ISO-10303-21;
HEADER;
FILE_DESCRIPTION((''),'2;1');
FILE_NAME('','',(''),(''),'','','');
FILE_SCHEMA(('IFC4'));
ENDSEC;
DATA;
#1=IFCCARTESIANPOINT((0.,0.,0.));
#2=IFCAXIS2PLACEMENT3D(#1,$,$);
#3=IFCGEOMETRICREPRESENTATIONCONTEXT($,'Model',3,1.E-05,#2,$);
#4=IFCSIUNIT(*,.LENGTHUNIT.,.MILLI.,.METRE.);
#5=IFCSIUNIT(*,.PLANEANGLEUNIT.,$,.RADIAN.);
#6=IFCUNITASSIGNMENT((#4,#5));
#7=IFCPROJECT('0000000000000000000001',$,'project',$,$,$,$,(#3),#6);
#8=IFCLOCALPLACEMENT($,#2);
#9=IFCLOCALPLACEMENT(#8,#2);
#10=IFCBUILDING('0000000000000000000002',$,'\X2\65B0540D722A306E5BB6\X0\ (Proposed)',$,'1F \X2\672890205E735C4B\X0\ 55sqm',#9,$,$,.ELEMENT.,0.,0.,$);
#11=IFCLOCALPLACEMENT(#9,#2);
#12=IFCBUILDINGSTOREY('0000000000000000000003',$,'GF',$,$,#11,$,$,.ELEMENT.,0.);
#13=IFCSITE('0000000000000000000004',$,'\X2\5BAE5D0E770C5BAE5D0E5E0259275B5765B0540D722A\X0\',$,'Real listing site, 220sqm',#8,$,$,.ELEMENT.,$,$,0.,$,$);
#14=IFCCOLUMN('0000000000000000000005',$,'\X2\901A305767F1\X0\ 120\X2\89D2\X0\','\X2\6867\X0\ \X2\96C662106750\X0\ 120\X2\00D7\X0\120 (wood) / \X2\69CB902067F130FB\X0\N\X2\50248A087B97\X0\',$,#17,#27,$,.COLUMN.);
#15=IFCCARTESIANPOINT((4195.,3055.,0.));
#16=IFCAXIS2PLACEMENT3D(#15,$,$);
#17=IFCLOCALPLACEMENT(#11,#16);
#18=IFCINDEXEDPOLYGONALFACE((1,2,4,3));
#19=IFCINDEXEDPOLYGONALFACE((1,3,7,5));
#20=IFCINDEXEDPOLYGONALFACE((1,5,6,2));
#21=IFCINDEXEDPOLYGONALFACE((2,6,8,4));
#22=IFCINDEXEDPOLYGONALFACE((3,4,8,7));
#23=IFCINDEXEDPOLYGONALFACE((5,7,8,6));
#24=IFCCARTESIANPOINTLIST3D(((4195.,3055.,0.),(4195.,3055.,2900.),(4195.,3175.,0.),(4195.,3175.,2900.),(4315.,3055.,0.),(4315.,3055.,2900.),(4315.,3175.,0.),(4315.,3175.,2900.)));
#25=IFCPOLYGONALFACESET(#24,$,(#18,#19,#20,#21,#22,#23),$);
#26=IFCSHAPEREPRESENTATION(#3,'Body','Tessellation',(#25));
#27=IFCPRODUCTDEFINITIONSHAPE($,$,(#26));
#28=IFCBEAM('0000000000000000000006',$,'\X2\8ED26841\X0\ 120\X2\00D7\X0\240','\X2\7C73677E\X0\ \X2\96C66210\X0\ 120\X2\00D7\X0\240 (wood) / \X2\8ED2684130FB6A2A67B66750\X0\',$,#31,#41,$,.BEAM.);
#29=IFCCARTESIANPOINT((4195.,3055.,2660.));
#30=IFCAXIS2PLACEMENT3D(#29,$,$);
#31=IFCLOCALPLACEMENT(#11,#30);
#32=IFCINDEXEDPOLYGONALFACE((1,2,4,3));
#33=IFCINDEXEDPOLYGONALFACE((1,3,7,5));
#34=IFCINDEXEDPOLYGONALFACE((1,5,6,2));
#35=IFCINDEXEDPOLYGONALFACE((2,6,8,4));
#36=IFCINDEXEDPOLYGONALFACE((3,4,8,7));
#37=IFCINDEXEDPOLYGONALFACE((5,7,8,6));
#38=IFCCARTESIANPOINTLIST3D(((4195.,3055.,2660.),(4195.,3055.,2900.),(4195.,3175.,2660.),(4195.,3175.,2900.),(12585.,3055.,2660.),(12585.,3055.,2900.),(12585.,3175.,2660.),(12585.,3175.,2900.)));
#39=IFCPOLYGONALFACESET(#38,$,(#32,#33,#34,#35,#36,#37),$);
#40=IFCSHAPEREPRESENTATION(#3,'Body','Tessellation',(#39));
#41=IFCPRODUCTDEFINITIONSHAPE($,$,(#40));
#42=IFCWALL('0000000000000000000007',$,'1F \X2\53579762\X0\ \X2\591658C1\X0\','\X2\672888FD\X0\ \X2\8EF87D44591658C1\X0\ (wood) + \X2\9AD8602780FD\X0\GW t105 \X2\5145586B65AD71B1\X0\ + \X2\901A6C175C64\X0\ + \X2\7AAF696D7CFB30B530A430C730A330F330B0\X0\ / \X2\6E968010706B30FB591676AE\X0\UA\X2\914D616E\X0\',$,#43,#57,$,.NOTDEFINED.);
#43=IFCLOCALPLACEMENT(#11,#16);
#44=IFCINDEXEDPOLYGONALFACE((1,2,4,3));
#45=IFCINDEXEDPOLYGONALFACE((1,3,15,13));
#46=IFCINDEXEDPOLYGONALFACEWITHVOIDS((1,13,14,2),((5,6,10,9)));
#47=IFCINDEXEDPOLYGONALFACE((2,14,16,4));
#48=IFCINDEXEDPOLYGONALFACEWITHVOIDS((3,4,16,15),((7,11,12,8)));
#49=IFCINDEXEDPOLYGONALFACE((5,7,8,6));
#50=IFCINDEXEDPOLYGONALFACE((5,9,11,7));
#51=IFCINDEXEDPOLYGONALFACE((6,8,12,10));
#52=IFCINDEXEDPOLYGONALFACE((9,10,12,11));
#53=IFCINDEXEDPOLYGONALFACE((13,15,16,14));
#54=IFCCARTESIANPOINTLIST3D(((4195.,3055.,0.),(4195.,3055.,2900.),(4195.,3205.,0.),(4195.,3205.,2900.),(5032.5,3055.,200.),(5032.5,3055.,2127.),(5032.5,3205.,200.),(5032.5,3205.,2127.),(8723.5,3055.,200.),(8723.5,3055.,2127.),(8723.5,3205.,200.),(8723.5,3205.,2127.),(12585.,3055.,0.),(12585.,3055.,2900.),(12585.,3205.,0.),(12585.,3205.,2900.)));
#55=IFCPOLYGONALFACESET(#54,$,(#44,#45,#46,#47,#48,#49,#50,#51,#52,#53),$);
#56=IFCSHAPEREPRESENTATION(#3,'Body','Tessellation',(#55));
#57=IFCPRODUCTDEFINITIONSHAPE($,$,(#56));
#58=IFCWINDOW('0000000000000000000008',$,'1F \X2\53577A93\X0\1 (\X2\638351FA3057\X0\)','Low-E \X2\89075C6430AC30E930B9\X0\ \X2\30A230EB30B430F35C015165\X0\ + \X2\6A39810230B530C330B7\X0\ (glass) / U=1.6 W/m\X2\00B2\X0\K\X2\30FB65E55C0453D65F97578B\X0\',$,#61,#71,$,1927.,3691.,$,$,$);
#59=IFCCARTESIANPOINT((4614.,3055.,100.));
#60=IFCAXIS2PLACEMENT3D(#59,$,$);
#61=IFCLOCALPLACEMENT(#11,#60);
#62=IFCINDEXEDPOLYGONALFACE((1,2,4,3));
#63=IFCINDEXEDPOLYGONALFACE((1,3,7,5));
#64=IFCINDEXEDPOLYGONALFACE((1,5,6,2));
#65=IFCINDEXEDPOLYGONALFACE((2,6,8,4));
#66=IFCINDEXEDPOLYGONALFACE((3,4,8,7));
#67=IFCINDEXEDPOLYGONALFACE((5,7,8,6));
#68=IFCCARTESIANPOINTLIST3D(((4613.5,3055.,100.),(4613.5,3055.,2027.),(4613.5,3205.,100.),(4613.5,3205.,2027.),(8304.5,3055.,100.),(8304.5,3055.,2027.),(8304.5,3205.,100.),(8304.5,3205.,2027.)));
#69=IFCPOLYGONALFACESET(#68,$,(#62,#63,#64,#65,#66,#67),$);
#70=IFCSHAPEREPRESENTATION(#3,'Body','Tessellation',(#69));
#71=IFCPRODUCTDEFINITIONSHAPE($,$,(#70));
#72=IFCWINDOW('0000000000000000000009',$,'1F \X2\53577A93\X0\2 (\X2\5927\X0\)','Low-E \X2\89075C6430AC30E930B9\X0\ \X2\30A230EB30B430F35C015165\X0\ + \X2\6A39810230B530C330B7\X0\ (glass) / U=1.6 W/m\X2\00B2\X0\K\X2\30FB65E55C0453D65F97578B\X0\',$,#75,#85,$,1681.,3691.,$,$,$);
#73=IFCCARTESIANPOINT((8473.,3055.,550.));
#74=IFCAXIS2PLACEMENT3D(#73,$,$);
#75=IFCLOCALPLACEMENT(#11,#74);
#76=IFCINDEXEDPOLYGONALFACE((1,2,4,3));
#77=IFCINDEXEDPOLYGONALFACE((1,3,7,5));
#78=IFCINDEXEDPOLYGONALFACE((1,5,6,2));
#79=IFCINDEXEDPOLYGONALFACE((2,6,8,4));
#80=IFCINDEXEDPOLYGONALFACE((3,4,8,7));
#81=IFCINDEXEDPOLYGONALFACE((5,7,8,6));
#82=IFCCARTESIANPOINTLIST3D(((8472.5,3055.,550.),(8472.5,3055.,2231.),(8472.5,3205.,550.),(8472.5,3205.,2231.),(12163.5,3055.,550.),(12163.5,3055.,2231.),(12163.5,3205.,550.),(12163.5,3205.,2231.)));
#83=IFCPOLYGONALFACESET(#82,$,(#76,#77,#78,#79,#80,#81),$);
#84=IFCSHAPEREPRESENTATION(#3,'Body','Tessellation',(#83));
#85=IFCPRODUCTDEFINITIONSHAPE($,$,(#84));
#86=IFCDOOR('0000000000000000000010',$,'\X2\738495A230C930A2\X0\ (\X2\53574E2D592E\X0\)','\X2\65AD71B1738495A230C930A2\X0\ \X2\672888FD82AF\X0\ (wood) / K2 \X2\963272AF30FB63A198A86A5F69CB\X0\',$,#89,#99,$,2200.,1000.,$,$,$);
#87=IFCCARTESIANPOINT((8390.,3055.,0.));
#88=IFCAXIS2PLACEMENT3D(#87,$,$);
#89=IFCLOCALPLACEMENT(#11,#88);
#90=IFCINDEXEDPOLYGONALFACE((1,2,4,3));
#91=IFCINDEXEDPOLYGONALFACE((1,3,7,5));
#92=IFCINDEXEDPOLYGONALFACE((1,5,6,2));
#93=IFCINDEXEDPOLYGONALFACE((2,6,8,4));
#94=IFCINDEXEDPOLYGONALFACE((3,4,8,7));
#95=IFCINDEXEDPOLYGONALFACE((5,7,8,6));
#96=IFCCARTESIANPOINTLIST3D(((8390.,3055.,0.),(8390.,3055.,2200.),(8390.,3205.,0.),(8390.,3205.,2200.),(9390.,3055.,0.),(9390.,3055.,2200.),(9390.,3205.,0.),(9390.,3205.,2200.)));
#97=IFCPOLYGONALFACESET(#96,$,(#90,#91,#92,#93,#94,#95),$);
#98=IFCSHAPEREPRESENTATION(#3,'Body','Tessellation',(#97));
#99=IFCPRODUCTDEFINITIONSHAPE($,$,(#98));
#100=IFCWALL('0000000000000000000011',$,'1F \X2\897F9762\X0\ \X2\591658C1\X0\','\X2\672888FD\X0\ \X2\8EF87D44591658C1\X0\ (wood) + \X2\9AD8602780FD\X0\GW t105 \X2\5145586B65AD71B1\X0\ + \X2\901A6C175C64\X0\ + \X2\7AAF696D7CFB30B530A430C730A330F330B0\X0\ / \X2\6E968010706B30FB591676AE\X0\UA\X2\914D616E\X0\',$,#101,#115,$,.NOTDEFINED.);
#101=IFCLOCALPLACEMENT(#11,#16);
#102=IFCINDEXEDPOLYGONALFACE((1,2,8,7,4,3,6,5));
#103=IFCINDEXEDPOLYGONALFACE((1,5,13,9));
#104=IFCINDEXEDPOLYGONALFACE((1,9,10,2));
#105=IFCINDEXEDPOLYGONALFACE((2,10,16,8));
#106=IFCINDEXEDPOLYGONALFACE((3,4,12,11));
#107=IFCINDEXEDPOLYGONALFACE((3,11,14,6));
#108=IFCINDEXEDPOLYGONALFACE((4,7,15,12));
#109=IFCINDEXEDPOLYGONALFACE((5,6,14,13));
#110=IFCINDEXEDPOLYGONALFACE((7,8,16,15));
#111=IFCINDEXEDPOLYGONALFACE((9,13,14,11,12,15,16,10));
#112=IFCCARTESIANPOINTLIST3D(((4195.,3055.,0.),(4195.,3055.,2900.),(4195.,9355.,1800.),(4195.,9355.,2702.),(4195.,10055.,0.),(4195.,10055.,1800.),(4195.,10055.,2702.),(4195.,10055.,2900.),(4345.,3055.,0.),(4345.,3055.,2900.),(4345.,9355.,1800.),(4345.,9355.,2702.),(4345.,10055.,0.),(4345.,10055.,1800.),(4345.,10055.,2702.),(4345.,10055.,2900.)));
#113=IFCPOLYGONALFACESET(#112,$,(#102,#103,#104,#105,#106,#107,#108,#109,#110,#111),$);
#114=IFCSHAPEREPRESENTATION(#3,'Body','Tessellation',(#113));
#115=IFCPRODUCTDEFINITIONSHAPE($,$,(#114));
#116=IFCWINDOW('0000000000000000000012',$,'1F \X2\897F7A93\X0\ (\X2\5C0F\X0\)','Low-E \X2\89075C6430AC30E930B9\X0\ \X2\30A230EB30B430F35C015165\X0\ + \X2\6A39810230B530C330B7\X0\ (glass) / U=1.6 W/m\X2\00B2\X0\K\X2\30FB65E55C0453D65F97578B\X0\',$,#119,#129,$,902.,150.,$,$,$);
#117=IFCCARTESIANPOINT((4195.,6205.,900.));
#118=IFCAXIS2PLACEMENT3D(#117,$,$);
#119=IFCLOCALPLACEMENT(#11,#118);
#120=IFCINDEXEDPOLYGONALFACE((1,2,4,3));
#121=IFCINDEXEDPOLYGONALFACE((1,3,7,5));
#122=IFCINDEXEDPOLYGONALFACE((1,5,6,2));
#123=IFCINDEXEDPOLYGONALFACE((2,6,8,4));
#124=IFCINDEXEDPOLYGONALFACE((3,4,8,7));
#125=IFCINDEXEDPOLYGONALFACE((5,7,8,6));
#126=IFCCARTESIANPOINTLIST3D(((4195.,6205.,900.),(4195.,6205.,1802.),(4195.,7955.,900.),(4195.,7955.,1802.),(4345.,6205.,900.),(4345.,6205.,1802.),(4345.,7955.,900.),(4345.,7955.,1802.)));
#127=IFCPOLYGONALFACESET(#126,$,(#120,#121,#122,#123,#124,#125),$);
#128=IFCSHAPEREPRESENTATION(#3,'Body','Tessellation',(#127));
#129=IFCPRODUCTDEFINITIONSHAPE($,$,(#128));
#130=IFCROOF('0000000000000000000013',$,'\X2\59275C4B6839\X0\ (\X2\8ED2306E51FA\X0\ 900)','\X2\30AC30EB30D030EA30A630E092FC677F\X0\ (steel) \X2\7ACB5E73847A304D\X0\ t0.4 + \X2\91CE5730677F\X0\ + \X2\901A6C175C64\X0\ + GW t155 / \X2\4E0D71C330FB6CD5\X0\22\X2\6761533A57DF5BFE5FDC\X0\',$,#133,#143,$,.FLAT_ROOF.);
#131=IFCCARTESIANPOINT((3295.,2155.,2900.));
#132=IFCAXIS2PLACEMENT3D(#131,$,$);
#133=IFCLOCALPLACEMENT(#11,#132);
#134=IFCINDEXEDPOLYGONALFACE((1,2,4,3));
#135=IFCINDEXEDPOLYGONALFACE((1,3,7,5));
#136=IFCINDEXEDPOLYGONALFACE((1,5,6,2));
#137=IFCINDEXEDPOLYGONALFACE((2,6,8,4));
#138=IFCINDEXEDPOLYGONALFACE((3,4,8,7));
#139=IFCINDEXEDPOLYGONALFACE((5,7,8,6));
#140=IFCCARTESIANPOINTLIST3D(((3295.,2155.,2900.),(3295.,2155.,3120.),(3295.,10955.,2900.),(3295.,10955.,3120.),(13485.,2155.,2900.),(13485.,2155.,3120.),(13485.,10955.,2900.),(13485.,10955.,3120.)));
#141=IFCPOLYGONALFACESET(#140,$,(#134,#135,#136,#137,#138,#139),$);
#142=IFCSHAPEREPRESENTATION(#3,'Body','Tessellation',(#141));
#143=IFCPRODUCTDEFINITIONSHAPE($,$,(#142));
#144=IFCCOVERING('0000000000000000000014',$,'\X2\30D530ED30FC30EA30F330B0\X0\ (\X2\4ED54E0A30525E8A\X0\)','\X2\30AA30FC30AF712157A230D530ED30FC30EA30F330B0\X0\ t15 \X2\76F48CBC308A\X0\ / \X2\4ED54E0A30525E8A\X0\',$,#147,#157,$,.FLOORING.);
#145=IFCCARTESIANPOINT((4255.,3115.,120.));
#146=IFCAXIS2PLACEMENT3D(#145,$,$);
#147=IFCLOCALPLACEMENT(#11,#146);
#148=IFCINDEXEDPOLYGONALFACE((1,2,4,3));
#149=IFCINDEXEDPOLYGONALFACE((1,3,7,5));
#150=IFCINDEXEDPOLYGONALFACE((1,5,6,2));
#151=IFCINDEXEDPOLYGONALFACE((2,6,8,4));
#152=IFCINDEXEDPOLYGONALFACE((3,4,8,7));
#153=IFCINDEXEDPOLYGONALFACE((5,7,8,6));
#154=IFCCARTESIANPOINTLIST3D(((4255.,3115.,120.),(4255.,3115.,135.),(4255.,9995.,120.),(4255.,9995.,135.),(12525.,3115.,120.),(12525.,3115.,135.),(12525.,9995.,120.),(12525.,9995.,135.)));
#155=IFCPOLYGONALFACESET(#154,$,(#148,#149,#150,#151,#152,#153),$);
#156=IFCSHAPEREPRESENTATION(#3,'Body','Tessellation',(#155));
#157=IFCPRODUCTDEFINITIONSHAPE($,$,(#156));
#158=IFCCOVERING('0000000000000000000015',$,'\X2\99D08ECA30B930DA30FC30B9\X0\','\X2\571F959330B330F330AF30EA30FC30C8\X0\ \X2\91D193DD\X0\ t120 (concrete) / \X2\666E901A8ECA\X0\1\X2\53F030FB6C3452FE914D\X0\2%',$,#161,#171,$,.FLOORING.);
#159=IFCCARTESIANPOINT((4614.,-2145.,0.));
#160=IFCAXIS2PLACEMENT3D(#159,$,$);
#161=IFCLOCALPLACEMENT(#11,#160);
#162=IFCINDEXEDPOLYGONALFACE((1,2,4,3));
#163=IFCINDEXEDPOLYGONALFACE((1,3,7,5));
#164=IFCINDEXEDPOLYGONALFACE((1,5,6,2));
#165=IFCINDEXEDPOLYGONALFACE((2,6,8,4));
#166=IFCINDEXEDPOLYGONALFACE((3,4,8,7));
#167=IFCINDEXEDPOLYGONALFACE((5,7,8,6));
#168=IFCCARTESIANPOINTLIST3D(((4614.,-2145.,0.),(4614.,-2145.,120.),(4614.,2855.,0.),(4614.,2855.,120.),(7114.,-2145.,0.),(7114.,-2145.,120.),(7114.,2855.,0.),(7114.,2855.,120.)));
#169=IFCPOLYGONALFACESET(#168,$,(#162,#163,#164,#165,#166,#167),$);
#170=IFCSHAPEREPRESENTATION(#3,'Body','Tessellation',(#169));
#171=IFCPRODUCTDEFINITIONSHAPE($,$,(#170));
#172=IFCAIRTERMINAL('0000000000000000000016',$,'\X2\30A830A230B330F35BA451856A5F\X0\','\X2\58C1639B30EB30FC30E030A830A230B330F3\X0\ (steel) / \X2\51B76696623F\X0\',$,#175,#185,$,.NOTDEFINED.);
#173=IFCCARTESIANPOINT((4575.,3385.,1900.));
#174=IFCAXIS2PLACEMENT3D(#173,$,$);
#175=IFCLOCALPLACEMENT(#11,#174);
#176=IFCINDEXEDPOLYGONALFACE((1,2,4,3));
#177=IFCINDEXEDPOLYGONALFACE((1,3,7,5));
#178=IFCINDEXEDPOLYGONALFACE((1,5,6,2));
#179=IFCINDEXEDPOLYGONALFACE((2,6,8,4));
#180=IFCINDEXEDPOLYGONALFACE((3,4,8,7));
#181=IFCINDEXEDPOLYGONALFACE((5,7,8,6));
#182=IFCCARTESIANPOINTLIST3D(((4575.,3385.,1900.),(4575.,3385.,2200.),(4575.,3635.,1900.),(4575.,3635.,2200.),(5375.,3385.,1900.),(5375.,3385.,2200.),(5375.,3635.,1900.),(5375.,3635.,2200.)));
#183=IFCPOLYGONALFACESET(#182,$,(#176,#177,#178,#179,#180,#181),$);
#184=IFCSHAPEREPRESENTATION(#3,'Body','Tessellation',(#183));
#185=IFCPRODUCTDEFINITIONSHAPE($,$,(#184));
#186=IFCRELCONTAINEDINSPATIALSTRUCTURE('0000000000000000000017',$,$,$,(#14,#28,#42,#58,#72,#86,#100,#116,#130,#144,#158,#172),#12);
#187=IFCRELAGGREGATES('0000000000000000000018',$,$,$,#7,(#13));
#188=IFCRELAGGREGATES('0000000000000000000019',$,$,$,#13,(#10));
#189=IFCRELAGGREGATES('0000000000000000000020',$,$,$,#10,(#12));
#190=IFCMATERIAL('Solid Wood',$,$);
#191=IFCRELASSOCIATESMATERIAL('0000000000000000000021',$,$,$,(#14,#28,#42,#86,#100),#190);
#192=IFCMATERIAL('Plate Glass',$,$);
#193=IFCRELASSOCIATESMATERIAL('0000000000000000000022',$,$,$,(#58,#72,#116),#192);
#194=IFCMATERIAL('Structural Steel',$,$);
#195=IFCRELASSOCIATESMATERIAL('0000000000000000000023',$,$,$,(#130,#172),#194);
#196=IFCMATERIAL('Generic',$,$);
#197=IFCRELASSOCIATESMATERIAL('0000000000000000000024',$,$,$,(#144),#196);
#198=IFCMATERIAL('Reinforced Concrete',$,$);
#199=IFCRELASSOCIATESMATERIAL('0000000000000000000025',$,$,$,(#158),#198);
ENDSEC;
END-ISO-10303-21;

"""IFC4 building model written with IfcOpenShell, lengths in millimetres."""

from ifc_helpers import new_model, si_unit, frame, frame_2d, origin, place, context, project, spatial, rectangle, extrude, material, element, fill, save


model = new_model("IFC4")

# Units and contexts
model_context = context("Model", 3, precision=1e-05, world=origin())
ifc_project = project(units=[si_unit("LENGTHUNIT", "METRE", prefix="MILLI"), si_unit("PLANEANGLEUNIT", "RADIAN")], contexts=[model_context])

# Site, building, storey
site_placement = place(None, origin())
site = spatial("IfcSite", under=ifc_project, at=site_placement, Name="宮崎県宮崎市大字新名爪", ObjectType="Real listing site, 220sqm", CompositionType="ELEMENT", RefElevation=0.0)
building_placement = place(site_placement, origin())
building = spatial("IfcBuilding", under=site, at=building_placement, Name="新名爪の家 (Proposed)", ObjectType="1F 木造平屋 55sqm", CompositionType="ELEMENT", ElevationOfRefHeight=0.0, ElevationOfTerrain=0.0)
storey_placement = place(building_placement, origin())
storey = spatial("IfcBuildingStorey", under=building, at=storey_placement, Name="GF", CompositionType="ELEMENT", Elevation=0.0)

# Column
ifc_material_1 = material(Name="Solid Wood")
column_1_placement = place(storey_placement, frame((4195.0, 3055.0, 0.0)))
element("IfcColumn", 1, at=column_1_placement, inside=storey, material=ifc_material_1, Name="通し柱 120角", Description="桧 集成材 120×120 (wood) / 構造柱・N値計算", PredefinedType="COLUMN", context=model_context, shape_type="SweptSolid", body=[
    extrude(rectangle(XDim=120.0, YDim=120.0, at=frame_2d((60.0, 60.0))), frame((4195.0, 3055.0, 0.0)), (0.0, 0.0, 1.0), 2900.0),
])

# Beam
beam_1_placement = place(storey_placement, frame((4195.0, 3055.0, 2660.0)))
element("IfcBeam", 2, at=beam_1_placement, inside=storey, material=ifc_material_1, Name="軒桁 120×240", Description="米松 集成 120×240 (wood) / 軒桁・横架材", PredefinedType="BEAM", context=model_context, shape_type="SweptSolid", body=[
    extrude(rectangle(XDim=8390.0, YDim=120.0, at=frame_2d((4195.0, 60.0))), frame((4195.0, 3055.0, 2660.0)), (0.0, 0.0, 1.0), 240.0),
])

# Shared definitions
ifc_material_2 = material(Name="Reinforced Concrete")

# Wall, openings, windows, door
wall_1_placement = place(storey_placement, frame((4195.0, 3055.0, 0.0)))
wall_1 = element("IfcWall", 3, at=wall_1_placement, inside=storey, material=ifc_material_1, Name="1F 南面 外壁", Description="木製 軸組外壁 (wood) + 高性能GW t105 充填断熱 + 通気層 + 窯業系サイディング / 準耐火・外皮UA配慮", PredefinedType="NOTDEFINED", context=model_context, shape_type="SweptSolid", body=[
    extrude(rectangle(XDim=8390.0, YDim=150.0, at=frame_2d((4195.0, 75.0))), frame((4195.0, 3055.0, 0.0)), (0.0, 0.0, 1.0), 2900.0),
])
opening_1_placement = place(storey_placement, frame((4614.0, 3055.0, 100.0)))
opening_1 = element("IfcOpeningElement", 4, at=opening_1_placement, cuts=wall_1, PredefinedType="NOTDEFINED", context=model_context, shape_type="SweptSolid", body=[
    extrude(rectangle(XDim=3691.0, YDim=150.0, at=frame_2d((1845.0, 75.0))), frame((4614.0, 3055.0, 100.0)), (0.0, 0.0, 1.0), 1927.0),
])
opening_2_placement = place(storey_placement, frame((8473.0, 3055.0, 550.0)))
opening_2 = element("IfcOpeningElement", 5, at=opening_2_placement, cuts=wall_1, PredefinedType="NOTDEFINED", context=model_context, shape_type="SweptSolid", body=[
    extrude(rectangle(XDim=3691.0, YDim=150.0, at=frame_2d((1845.0, 75.0))), frame((8473.0, 3055.0, 550.0)), (0.0, 0.0, 1.0), 1681.0),
])
opening_3_placement = place(storey_placement, frame((8390.0, 3055.0, 0.0)))
opening_3 = element("IfcOpeningElement", 6, at=opening_3_placement, cuts=wall_1, PredefinedType="NOTDEFINED", context=model_context, shape_type="SweptSolid", body=[
    extrude(rectangle(XDim=1000.0, YDim=150.0, at=frame_2d((500.0, 75.0))), frame((8390.0, 3055.0, 0.0)), (0.0, 0.0, 1.0), 2200.0),
])
ifc_material_3 = material(Name="Plate Glass")
window_1_placement = place(storey_placement, frame((4614.0, 3055.0, 100.0)))
window_1 = element("IfcWindow", 7, at=window_1_placement, inside=storey, material=ifc_material_3, Name="1F 南窓1 (掃出し)", Description="Low-E 複層ガラス アルゴン封入 + 樹脂サッシ (glass) / U=1.6 W/m²K・日射取得型", OverallHeight=1927.0, OverallWidth=3691.0, context=model_context, shape_type="SweptSolid", body=[
    extrude(rectangle(XDim=3691.0, YDim=150.0, at=frame_2d((1845.0, 75.0))), frame((4614.0, 3055.0, 100.0)), (0.0, 0.0, 1.0), 1927.0),
])
fill(opening_1, window_1)
window_2_placement = place(storey_placement, frame((8473.0, 3055.0, 550.0)))
window_2 = element("IfcWindow", 8, at=window_2_placement, inside=storey, material=ifc_material_3, Name="1F 南窓2 (大)", Description="Low-E 複層ガラス アルゴン封入 + 樹脂サッシ (glass) / U=1.6 W/m²K・日射取得型", OverallHeight=1681.0, OverallWidth=3691.0, context=model_context, shape_type="SweptSolid", body=[
    extrude(rectangle(XDim=3691.0, YDim=150.0, at=frame_2d((1845.0, 75.0))), frame((8473.0, 3055.0, 550.0)), (0.0, 0.0, 1.0), 1681.0),
])
fill(opening_2, window_2)
door_placement = place(storey_placement, frame((8390.0, 3055.0, 0.0)))
door = element("IfcDoor", 9, at=door_placement, inside=storey, material=ifc_material_1, Name="玄関ドア (南中央)", Description="断熱玄関ドア 木製芯 (wood) / K2 防犯・採風機構", OverallHeight=2200.0, OverallWidth=1000.0, context=model_context, shape_type="SweptSolid", body=[
    extrude(rectangle(XDim=1000.0, YDim=150.0, at=frame_2d((500.0, 75.0))), frame((8390.0, 3055.0, 0.0)), (0.0, 0.0, 1.0), 2200.0),
])
fill(opening_3, door)

# Wall, opening, window
wall_2_placement = place(storey_placement, frame((4195.0, 3055.0, 0.0)))
wall_2 = element("IfcWall", 10, at=wall_2_placement, inside=storey, material=ifc_material_1, Name="1F 西面 外壁", Description="木製 軸組外壁 (wood) + 高性能GW t105 充填断熱 + 通気層 + 窯業系サイディング / 準耐火・外皮UA配慮", PredefinedType="NOTDEFINED", context=model_context, shape_type="SweptSolid", body=[
    extrude(rectangle(XDim=150.0, YDim=7000.0, at=frame_2d((75.0, 3500.0))), frame((4195.0, 3055.0, 0.0)), (0.0, 0.0, 1.0), 2900.0),
])
opening_4_placement = place(storey_placement, frame((4195.0, 6205.0, 900.0)))
opening_4 = element("IfcOpeningElement", 11, at=opening_4_placement, cuts=wall_2, PredefinedType="NOTDEFINED", context=model_context, shape_type="SweptSolid", body=[
    extrude(rectangle(XDim=150.0, YDim=1750.0, at=frame_2d((75.0, 875.0))), frame((4195.0, 6205.0, 900.0)), (0.0, 0.0, 1.0), 902.0),
])
window_3_placement = place(storey_placement, frame((4195.0, 6205.0, 900.0)))
window_3 = element("IfcWindow", 12, at=window_3_placement, inside=storey, material=ifc_material_3, Name="1F 西窓 (小)", Description="Low-E 複層ガラス アルゴン封入 + 樹脂サッシ (glass) / U=1.6 W/m²K・日射取得型", OverallHeight=902.0, OverallWidth=150.0, context=model_context, shape_type="SweptSolid", body=[
    extrude(rectangle(XDim=150.0, YDim=1750.0, at=frame_2d((75.0, 875.0))), frame((4195.0, 6205.0, 900.0)), (0.0, 0.0, 1.0), 902.0),
])
fill(opening_4, window_3)

# Roof
ifc_material_4 = material(Name="Structural Steel")
roof_placement = place(storey_placement, frame((3295.0, 2155.0, 2900.0)))
element("IfcRoof", 13, at=roof_placement, inside=storey, material=ifc_material_4, Name="大屋根 (軒の出 900)", Description="ガルバリウム鋼板 (steel) 立平葺き t0.4 + 野地板 + 通気層 + GW t155 / 不燃・法22条区域対応", PredefinedType="FLAT_ROOF", context=model_context, shape_type="SweptSolid", body=[
    extrude(rectangle(XDim=10190.0, YDim=8800.0, at=frame_2d((5095.0, 4400.0))), frame((3295.0, 2155.0, 2900.0)), (0.0, 0.0, 1.0), 220.0),
])

# Coverings
ifc_material_5 = material(Name="Generic")
covering_1_placement = place(storey_placement, frame((4255.0, 3115.0, 120.0)))
element("IfcCovering", 14, at=covering_1_placement, inside=storey, material=ifc_material_5, Name="フローリング (仕上げ床)", Description="オーク無垢フローリング t15 直貼り / 仕上げ床", PredefinedType="FLOORING", context=model_context, shape_type="SweptSolid", body=[
    extrude(rectangle(XDim=8270.0, YDim=6880.0, at=frame_2d((4135.0, 3440.0))), frame((4255.0, 3115.0, 120.0)), (0.0, 0.0, 1.0), 15.0),
])
covering_2_placement = place(storey_placement, frame((4614.0, -2145.0, 0.0)))
element("IfcCovering", 15, at=covering_2_placement, inside=storey, material=ifc_material_2, Name="駐車スペース", Description="土間コンクリート 金鏝 t120 (concrete) / 普通車1台・水勾配2%", PredefinedType="FLOORING", context=model_context, shape_type="SweptSolid", body=[
    extrude(rectangle(XDim=2500.0, YDim=5000.0, at=frame_2d((1250.0, 2500.0))), frame((4614.0, -2145.0, 0.0)), (0.0, 0.0, 1.0), 120.0),
])

# Air terminal
air_terminal_placement = place(storey_placement, frame((4575.0, 3385.0, 1900.0)))
element("IfcAirTerminal", 16, at=air_terminal_placement, inside=storey, material=ifc_material_4, Name="エアコン室内機", Description="壁掛ルームエアコン (steel) / 冷暖房", PredefinedType="NOTDEFINED", context=model_context, shape_type="SweptSolid", body=[
    extrude(rectangle(XDim=800.0, YDim=250.0, at=frame_2d((400.0, 125.0))), frame((4575.0, 3385.0, 1900.0)), (0.0, 0.0, 1.0), 300.0),
])

save(model, "model.ifc")
